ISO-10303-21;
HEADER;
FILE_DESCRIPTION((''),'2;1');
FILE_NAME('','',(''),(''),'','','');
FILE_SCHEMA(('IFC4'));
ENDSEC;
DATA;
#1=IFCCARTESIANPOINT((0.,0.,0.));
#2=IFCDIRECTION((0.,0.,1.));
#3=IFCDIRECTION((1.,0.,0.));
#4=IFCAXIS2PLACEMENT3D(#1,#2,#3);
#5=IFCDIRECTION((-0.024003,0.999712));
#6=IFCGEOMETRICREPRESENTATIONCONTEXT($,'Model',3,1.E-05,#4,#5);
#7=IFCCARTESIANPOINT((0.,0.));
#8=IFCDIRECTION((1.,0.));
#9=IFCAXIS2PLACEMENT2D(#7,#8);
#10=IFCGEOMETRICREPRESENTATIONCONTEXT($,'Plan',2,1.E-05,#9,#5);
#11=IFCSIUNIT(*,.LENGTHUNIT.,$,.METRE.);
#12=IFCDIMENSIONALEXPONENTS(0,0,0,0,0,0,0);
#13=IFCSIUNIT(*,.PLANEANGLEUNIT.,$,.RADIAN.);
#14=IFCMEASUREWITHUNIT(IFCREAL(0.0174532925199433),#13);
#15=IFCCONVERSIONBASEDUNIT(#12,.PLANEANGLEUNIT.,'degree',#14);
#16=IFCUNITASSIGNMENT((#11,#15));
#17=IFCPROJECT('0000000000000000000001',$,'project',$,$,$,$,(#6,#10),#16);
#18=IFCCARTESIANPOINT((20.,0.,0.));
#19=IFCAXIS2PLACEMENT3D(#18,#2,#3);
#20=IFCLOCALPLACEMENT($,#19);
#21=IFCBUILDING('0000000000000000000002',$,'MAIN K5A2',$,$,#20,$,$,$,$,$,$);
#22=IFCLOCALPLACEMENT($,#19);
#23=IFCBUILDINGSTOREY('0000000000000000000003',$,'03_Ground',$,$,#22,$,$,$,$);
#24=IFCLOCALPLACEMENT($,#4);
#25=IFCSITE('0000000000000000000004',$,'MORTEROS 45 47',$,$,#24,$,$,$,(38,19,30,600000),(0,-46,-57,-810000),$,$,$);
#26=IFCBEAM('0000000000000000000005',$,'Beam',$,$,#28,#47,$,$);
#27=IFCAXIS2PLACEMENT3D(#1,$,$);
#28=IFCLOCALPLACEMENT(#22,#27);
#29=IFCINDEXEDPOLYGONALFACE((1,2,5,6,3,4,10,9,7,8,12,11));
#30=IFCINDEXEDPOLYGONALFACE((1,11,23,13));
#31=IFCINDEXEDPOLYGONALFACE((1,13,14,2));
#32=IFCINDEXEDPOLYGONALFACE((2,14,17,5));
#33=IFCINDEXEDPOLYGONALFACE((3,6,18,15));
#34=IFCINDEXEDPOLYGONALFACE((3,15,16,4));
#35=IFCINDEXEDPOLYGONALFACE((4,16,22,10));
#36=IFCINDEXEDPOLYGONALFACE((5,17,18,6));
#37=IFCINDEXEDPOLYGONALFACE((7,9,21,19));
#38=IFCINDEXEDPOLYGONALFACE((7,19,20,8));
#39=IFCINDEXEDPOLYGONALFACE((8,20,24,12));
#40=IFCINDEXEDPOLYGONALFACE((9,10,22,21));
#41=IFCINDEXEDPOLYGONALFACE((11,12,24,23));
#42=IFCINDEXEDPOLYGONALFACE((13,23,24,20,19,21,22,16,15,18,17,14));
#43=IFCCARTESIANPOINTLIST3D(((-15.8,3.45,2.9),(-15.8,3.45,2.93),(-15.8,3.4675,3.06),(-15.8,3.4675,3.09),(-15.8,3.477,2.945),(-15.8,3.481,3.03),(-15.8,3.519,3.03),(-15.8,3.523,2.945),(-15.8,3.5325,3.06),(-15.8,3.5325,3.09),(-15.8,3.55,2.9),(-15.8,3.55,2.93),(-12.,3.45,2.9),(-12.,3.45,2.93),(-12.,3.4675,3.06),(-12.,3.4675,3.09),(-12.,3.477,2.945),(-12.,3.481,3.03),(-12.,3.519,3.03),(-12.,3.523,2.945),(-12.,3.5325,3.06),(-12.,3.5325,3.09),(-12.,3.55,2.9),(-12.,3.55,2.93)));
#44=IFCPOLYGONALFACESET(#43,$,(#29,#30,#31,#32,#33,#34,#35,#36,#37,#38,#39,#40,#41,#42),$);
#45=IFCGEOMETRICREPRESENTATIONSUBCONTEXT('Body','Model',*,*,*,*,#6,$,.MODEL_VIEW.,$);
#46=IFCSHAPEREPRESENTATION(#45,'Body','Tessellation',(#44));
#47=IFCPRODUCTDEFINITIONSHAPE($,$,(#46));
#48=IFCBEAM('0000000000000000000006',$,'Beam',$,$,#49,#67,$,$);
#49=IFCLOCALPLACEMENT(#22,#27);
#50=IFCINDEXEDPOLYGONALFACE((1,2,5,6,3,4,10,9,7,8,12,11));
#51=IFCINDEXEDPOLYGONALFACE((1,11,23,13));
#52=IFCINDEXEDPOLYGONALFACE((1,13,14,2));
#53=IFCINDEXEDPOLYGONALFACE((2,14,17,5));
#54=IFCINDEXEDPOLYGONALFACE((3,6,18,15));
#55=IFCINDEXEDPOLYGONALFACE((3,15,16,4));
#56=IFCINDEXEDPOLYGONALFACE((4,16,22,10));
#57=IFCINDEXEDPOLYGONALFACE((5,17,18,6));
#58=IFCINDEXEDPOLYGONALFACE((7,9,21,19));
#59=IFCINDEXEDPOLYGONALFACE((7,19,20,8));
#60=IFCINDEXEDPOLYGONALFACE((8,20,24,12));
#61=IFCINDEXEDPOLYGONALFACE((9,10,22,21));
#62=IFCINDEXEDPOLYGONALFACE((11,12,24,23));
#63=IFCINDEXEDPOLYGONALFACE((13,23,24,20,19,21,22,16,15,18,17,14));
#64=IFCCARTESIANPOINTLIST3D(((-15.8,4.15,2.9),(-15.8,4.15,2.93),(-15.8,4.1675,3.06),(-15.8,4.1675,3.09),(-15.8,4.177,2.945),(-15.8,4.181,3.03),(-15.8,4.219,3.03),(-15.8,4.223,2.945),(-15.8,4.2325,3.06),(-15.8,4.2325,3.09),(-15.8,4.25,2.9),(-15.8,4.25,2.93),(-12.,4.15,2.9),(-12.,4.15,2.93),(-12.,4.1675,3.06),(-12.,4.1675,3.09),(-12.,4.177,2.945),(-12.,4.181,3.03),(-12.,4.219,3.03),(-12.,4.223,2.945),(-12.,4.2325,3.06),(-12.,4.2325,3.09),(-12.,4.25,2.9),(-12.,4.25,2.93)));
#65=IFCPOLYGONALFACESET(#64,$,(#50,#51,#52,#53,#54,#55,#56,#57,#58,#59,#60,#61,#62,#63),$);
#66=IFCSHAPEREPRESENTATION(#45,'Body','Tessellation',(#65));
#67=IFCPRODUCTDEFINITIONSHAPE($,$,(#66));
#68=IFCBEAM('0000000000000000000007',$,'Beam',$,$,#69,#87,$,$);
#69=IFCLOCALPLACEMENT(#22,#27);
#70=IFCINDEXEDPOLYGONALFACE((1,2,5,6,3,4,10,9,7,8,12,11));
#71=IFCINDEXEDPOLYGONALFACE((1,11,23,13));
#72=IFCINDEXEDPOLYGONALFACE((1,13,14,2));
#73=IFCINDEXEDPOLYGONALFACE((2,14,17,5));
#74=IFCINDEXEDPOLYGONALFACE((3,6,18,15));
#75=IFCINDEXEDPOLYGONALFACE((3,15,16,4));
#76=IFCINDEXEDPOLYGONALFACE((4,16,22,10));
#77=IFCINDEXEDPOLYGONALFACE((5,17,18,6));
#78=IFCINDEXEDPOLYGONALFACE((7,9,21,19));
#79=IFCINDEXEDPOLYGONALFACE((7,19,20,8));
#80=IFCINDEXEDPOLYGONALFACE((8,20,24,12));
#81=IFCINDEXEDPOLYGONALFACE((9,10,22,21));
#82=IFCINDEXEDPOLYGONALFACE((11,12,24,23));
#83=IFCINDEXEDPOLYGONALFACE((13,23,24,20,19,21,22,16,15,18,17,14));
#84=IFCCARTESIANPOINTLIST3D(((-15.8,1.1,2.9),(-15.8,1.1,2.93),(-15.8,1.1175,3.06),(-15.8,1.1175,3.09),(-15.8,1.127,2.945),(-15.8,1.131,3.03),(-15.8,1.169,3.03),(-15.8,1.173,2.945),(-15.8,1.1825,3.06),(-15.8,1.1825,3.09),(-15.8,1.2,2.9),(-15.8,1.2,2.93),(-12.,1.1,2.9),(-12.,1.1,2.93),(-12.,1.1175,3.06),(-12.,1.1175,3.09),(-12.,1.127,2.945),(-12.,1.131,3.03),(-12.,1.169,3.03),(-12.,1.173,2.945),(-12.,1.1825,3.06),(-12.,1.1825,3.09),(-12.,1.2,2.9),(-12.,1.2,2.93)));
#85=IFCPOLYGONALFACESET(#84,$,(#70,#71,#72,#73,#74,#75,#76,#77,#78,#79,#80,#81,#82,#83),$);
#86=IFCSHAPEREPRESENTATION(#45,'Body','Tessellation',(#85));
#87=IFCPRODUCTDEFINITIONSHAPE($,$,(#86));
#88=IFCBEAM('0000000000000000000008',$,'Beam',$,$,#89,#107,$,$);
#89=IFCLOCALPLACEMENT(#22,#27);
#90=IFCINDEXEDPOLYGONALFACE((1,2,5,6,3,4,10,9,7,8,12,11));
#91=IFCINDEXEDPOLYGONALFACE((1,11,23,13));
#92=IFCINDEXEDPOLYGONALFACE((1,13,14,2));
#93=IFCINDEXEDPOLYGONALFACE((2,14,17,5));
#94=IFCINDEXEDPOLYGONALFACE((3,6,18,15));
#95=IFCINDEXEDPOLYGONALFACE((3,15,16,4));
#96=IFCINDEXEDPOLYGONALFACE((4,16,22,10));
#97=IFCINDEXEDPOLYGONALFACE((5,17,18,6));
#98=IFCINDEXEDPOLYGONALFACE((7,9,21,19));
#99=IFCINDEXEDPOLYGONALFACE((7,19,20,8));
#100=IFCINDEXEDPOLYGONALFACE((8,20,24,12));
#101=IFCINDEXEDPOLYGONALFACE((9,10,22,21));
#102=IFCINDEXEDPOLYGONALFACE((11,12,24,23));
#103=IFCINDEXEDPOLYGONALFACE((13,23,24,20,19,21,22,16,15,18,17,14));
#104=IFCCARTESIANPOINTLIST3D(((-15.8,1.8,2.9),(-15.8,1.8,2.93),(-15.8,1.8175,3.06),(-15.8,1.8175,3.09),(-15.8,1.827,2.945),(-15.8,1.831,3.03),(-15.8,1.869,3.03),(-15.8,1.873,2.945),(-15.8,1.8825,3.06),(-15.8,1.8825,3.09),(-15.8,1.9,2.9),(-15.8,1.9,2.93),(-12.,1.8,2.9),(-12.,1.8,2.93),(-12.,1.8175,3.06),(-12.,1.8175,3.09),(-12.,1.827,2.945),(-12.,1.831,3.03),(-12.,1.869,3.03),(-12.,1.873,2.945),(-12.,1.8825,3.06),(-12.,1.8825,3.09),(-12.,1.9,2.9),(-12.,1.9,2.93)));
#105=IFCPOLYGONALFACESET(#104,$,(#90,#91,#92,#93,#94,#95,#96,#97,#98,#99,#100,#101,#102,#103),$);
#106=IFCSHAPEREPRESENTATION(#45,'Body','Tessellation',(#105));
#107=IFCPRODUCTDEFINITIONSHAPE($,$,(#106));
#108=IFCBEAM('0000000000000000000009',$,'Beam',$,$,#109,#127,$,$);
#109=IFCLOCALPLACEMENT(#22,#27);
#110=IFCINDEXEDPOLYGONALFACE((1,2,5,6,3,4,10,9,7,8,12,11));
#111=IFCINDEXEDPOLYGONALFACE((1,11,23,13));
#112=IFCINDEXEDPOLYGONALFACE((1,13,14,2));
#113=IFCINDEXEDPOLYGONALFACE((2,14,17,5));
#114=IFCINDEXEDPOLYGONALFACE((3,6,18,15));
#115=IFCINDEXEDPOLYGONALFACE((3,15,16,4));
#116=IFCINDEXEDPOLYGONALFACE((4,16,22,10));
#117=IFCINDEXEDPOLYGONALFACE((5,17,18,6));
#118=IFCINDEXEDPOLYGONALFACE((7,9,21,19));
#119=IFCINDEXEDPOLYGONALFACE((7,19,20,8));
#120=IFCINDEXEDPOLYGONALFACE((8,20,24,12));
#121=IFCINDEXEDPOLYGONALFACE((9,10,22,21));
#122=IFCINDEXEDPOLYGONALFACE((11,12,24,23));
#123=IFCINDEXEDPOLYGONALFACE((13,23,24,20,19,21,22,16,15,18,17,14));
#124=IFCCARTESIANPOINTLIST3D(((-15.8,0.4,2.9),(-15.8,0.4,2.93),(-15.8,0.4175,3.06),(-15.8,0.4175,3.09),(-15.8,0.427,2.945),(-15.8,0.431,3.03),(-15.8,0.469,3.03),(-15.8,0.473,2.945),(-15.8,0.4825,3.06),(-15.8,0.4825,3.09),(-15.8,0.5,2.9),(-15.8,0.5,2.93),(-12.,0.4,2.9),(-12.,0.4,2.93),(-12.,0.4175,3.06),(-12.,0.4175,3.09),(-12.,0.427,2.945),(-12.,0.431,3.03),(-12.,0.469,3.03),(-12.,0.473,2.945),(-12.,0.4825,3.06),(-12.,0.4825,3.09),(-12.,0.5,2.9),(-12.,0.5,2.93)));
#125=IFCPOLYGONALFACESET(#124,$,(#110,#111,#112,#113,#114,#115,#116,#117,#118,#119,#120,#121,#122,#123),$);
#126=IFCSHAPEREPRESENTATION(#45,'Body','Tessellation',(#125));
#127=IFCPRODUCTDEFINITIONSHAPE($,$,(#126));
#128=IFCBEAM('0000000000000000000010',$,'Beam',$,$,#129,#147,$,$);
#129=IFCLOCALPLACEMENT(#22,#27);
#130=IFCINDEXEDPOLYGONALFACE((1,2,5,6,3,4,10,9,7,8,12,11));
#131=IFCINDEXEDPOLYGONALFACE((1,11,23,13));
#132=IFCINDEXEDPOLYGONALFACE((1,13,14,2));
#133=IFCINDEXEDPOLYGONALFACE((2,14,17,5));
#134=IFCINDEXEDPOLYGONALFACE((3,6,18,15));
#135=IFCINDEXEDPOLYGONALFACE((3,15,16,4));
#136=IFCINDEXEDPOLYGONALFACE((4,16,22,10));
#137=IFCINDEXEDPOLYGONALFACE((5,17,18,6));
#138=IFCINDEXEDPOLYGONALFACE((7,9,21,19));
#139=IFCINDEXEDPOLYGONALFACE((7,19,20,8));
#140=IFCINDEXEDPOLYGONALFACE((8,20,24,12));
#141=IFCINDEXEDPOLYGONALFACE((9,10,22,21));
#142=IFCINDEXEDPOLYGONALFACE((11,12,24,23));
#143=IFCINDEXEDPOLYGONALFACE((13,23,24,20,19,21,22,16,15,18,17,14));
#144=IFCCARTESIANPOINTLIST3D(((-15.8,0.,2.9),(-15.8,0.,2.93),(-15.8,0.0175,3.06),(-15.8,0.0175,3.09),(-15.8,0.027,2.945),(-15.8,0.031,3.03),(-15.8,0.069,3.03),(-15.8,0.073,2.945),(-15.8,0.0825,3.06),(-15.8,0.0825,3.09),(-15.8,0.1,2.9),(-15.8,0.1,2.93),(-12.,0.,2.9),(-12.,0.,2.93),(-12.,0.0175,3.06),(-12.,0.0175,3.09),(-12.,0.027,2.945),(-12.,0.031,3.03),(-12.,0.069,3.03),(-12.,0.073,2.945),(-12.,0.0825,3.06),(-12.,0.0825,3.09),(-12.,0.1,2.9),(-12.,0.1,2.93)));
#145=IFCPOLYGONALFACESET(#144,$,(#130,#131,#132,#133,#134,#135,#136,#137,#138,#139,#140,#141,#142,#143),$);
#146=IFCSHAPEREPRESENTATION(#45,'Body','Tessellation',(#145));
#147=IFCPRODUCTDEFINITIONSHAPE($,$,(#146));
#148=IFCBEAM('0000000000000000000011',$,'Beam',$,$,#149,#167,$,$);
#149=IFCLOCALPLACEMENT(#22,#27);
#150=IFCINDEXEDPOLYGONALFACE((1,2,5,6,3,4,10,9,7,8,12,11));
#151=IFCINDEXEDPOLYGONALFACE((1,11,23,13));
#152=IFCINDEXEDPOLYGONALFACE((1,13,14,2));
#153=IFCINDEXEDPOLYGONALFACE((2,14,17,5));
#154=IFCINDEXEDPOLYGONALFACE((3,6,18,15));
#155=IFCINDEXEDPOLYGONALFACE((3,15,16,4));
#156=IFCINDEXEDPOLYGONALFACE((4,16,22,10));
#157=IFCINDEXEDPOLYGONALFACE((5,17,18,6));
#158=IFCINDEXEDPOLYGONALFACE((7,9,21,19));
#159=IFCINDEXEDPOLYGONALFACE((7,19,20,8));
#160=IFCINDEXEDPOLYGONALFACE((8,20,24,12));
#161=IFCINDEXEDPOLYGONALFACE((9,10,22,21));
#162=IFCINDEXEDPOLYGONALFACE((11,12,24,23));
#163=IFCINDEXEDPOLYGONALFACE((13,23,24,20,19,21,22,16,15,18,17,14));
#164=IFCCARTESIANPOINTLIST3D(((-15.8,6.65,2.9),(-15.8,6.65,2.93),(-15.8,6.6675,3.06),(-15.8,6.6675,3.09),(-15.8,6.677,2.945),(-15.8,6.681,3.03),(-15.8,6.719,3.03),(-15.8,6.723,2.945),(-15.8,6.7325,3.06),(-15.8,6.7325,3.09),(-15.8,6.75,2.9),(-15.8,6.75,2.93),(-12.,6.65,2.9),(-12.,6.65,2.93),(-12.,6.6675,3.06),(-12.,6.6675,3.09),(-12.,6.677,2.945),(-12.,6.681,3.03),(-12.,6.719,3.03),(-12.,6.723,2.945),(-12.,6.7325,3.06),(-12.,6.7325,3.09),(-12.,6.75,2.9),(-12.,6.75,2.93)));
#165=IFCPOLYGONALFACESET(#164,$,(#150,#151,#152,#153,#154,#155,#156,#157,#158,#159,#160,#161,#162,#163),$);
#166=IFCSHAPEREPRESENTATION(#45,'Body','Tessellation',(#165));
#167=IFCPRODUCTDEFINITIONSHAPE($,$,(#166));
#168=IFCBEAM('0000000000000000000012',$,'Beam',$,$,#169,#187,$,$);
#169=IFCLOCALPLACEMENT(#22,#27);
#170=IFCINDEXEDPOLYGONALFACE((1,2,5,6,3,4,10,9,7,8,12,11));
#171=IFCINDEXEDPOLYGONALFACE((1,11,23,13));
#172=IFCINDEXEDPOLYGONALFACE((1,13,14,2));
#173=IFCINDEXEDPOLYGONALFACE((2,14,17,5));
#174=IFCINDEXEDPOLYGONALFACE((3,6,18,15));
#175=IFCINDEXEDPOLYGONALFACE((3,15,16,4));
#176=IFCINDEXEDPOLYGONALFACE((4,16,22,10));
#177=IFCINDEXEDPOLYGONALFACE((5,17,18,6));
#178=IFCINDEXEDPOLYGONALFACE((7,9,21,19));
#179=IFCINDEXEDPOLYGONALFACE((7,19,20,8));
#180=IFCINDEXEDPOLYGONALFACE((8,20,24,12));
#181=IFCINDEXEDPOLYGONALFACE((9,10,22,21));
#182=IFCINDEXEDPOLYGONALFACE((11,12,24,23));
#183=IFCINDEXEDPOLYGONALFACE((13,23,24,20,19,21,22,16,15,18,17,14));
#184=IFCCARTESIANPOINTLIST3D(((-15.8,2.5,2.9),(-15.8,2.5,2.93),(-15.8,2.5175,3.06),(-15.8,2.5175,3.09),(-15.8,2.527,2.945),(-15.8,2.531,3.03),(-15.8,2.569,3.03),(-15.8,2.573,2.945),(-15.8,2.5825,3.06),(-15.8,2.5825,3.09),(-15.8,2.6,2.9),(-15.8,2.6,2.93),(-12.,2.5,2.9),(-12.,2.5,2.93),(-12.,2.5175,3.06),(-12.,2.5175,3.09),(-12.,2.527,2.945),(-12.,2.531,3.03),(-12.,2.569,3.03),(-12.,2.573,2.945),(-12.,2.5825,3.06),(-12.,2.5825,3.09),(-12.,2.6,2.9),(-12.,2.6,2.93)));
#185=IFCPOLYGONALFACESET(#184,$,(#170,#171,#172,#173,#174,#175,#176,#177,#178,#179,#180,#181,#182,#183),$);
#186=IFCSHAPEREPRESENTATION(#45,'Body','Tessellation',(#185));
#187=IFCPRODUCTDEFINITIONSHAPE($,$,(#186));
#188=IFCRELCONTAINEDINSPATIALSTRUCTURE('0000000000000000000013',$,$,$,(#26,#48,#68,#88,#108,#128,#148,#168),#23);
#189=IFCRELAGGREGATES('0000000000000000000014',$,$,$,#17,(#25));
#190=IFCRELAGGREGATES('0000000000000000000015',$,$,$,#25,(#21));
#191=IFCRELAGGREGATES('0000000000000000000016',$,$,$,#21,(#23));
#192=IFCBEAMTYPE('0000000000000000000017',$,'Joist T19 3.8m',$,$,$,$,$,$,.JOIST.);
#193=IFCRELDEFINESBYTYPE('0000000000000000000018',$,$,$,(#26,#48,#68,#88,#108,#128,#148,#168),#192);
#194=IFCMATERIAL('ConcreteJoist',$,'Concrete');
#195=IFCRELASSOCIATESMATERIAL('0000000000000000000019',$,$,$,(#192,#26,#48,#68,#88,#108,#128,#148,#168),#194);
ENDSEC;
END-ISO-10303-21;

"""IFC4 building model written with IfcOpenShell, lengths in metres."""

from ifc_helpers import new_model, entity, si_unit, converted_unit, direction, frame, origin_with_axes, origin_2d_with_axis, place, context, subcontext, project, spatial, indexed_curve, outline, extrude, material, material_profile, profile_set, profile_usage, type_object, element, save


model = new_model("IFC4")

# Units and contexts
model_context = context("Model", 3, precision=1e-05, world=origin_with_axes(), true_north=direction((-0.024003, 0.999712)))
plan_context = context("Plan", 2, precision=1e-05, world=origin_2d_with_axis(), true_north=direction((-0.024003, 0.999712)))
body_context_1 = subcontext(model_context, "Body", "Model", "MODEL_VIEW")
ifc_project = project(units=[si_unit("LENGTHUNIT", "METRE"), converted_unit("PLANEANGLEUNIT", "degree", entity("IfcReal", 0.0174532925199433), si_unit("PLANEANGLEUNIT", "RADIAN"), dimensions=[0, 0, 0, 0, 0, 0, 0])], contexts=[model_context, plan_context])

# Site, building, storey
site_placement = place(None, origin_with_axes())
site = spatial("IfcSite", under=ifc_project, at=site_placement, Name="MORTEROS 45 47", RefLatitude=(38, 19, 30, 600000), RefLongitude=(0, -46, -57, -810000))
building_placement = place(None, frame((20.0, 0.0, 0.0), z_axis=(0.0, 0.0, 1.0), x_axis=(1.0, 0.0, 0.0)))
building = spatial("IfcBuilding", under=site, at=building_placement, Name="MAIN K5A2")
storey_placement = place(None, frame((20.0, 0.0, 0.0), z_axis=(0.0, 0.0, 1.0), x_axis=(1.0, 0.0, 0.0)))
storey = spatial("IfcBuildingStorey", under=building, at=storey_placement, Name="03_Ground")

# Beams
ifc_material = material(Name="ConcreteJoist", Category="Concrete")
ifc_material_profile_1 = material_profile(ifc_material, outline(indexed_curve([(0.019, 0.13), (0.023, 0.045), (0.05, 0.03), (0.05, 0.0), (-0.05, 0.0), (-0.05, 0.03), (-0.023, 0.045), (-0.019, 0.13), (-0.0325, 0.16), (-0.0325, 0.19), (0.0325, 0.19), (0.0325, 0.16), (0.019, 0.13)])))
ifc_profile_set_1 = profile_set([ifc_material_profile_1], Name="JoistMaterialProfileSet")
ifc_material_profile_2 = material_profile(ifc_material, outline(indexed_curve([(0.019, 0.13), (0.023, 0.045), (0.05, 0.03), (0.05, 0.0), (-0.05, 0.0), (-0.05, 0.03), (-0.023, 0.045), (-0.019, 0.13), (-0.0325, 0.16), (-0.0325, 0.19), (0.0325, 0.19), (0.0325, 0.16), (0.019, 0.13)])))
ifc_profile_set_2 = profile_set([ifc_material_profile_2], Name="JoistMaterialProfileSet")
beam_type_1 = type_object("IfcBeamType", Name="Joist T19 3.8m", PredefinedType="JOIST", material=ifc_profile_set_2)
ifc_profile_usage_1 = profile_usage(ifc_profile_set_1)
beam_1_placement = place(None, frame((4.2, 3.5, 2.9), z_axis=(1.0, 0.0, 0.0), x_axis=(0.0, 1.0, 0.0)))
element("IfcBeam", 1, at=beam_1_placement, inside=storey, type_object=beam_type_1, material=ifc_profile_usage_1, Name="Beam", context=body_context_1, shape_type="SweptSolid", body=[
    extrude(outline(indexed_curve([(0.019, 0.13), (0.023, 0.045), (0.05, 0.03), (0.05, 0.0), (-0.05, 0.0), (-0.05, 0.03), (-0.023, 0.045), (-0.019, 0.13), (-0.0325, 0.16), (-0.0325, 0.19), (0.0325, 0.19), (0.0325, 0.16), (0.019, 0.13)])), origin_with_axes(), (0.0, 0.0, 1.0), 3.8),
])
ifc_profile_usage_2 = profile_usage(ifc_profile_set_1)
beam_2_placement = place(None, frame((4.2, 4.2, 2.9), z_axis=(1.0, 0.0, 0.0), x_axis=(0.0, 1.0, 0.0)))
element("IfcBeam", 2, at=beam_2_placement, inside=storey, type_object=beam_type_1, material=ifc_profile_usage_2, Name="Beam", context=body_context_1, shape_type="SweptSolid", body=[
    extrude(outline(indexed_curve([(0.019, 0.13), (0.023, 0.045), (0.05, 0.03), (0.05, 0.0), (-0.05, 0.0), (-0.05, 0.03), (-0.023, 0.045), (-0.019, 0.13), (-0.0325, 0.16), (-0.0325, 0.19), (0.0325, 0.19), (0.0325, 0.16), (0.019, 0.13)])), origin_with_axes(), (0.0, 0.0, 1.0), 3.8),
])
ifc_profile_usage_3 = profile_usage(ifc_profile_set_1)
beam_3_placement = place(None, frame((4.2, 1.15, 2.9), z_axis=(1.0, 0.0, 0.0), x_axis=(0.0, 1.0, 0.0)))
element("IfcBeam", 3, at=beam_3_placement, inside=storey, type_object=beam_type_1, material=ifc_profile_usage_3, Name="Beam", context=body_context_1, shape_type="SweptSolid", body=[
    extrude(outline(indexed_curve([(0.019, 0.13), (0.023, 0.045), (0.05, 0.03), (0.05, 0.0), (-0.05, 0.0), (-0.05, 0.03), (-0.023, 0.045), (-0.019, 0.13), (-0.0325, 0.16), (-0.0325, 0.19), (0.0325, 0.19), (0.0325, 0.16), (0.019, 0.13)])), origin_with_axes(), (0.0, 0.0, 1.0), 3.8),
])
ifc_profile_usage_4 = profile_usage(ifc_profile_set_1)
beam_4_placement = place(None, frame((4.2, 1.85, 2.9), z_axis=(1.0, 0.0, 0.0), x_axis=(0.0, 1.0, 0.0)))
element("IfcBeam", 4, at=beam_4_placement, inside=storey, type_object=beam_type_1, material=ifc_profile_usage_4, Name="Beam", context=body_context_1, shape_type="SweptSolid", body=[
    extrude(outline(indexed_curve([(0.019, 0.13), (0.023, 0.045), (0.05, 0.03), (0.05, 0.0), (-0.05, 0.0), (-0.05, 0.03), (-0.023, 0.045), (-0.019, 0.13), (-0.0325, 0.16), (-0.0325, 0.19), (0.0325, 0.19), (0.0325, 0.16), (0.019, 0.13)])), origin_with_axes(), (0.0, 0.0, 1.0), 3.8),
])
ifc_profile_usage_5 = profile_usage(ifc_profile_set_1)
beam_5_placement = place(None, frame((4.2, 0.45, 2.9), z_axis=(1.0, 0.0, 0.0), x_axis=(0.0, 1.0, 0.0)))
element("IfcBeam", 5, at=beam_5_placement, inside=storey, type_object=beam_type_1, material=ifc_profile_usage_5, Name="Beam", context=body_context_1, shape_type="SweptSolid", body=[
    extrude(outline(indexed_curve([(0.019, 0.13), (0.023, 0.045), (0.05, 0.03), (0.05, 0.0), (-0.05, 0.0), (-0.05, 0.03), (-0.023, 0.045), (-0.019, 0.13), (-0.0325, 0.16), (-0.0325, 0.19), (0.0325, 0.19), (0.0325, 0.16), (0.019, 0.13)])), origin_with_axes(), (0.0, 0.0, 1.0), 3.8),
])
ifc_profile_usage_6 = profile_usage(ifc_profile_set_1)
beam_6_placement = place(None, frame((4.2, 0.05, 2.9), z_axis=(1.0, 0.0, 0.0), x_axis=(0.0, 1.0, 0.0)))
element("IfcBeam", 6, at=beam_6_placement, inside=storey, type_object=beam_type_1, material=ifc_profile_usage_6, Name="Beam", context=body_context_1, shape_type="SweptSolid", body=[
    extrude(outline(indexed_curve([(0.019, 0.13), (0.023, 0.045), (0.05, 0.03), (0.05, 0.0), (-0.05, 0.0), (-0.05, 0.03), (-0.023, 0.045), (-0.019, 0.13), (-0.0325, 0.16), (-0.0325, 0.19), (0.0325, 0.19), (0.0325, 0.16), (0.019, 0.13)])), origin_with_axes(), (0.0, 0.0, 1.0), 3.8),
])
ifc_profile_usage_7 = profile_usage(ifc_profile_set_1)
beam_7_placement = place(None, frame((4.2, 6.7, 2.9), z_axis=(1.0, 0.0, 0.0), x_axis=(0.0, 1.0, 0.0)))
element("IfcBeam", 7, at=beam_7_placement, inside=storey, type_object=beam_type_1, material=ifc_profile_usage_7, Name="Beam", context=body_context_1, shape_type="SweptSolid", body=[
    extrude(outline(indexed_curve([(0.019, 0.13), (0.023, 0.045), (0.05, 0.03), (0.05, 0.0), (-0.05, 0.0), (-0.05, 0.03), (-0.023, 0.045), (-0.019, 0.13), (-0.0325, 0.16), (-0.0325, 0.19), (0.0325, 0.19), (0.0325, 0.16), (0.019, 0.13)])), origin_with_axes(), (0.0, 0.0, 1.0), 3.8),
])
ifc_profile_usage_8 = profile_usage(ifc_profile_set_1)
beam_8_placement = place(None, frame((4.2, 2.55, 2.9), z_axis=(1.0, 0.0, 0.0), x_axis=(0.0, 1.0, 0.0)))
element("IfcBeam", 8, at=beam_8_placement, inside=storey, type_object=beam_type_1, material=ifc_profile_usage_8, Name="Beam", context=body_context_1, shape_type="SweptSolid", body=[
    extrude(outline(indexed_curve([(0.019, 0.13), (0.023, 0.045), (0.05, 0.03), (0.05, 0.0), (-0.05, 0.0), (-0.05, 0.03), (-0.023, 0.045), (-0.019, 0.13), (-0.0325, 0.16), (-0.0325, 0.19), (0.0325, 0.19), (0.0325, 0.16), (0.019, 0.13)])), origin_with_axes(), (0.0, 0.0, 1.0), 3.8),
])

save(model, "model.ifc")
